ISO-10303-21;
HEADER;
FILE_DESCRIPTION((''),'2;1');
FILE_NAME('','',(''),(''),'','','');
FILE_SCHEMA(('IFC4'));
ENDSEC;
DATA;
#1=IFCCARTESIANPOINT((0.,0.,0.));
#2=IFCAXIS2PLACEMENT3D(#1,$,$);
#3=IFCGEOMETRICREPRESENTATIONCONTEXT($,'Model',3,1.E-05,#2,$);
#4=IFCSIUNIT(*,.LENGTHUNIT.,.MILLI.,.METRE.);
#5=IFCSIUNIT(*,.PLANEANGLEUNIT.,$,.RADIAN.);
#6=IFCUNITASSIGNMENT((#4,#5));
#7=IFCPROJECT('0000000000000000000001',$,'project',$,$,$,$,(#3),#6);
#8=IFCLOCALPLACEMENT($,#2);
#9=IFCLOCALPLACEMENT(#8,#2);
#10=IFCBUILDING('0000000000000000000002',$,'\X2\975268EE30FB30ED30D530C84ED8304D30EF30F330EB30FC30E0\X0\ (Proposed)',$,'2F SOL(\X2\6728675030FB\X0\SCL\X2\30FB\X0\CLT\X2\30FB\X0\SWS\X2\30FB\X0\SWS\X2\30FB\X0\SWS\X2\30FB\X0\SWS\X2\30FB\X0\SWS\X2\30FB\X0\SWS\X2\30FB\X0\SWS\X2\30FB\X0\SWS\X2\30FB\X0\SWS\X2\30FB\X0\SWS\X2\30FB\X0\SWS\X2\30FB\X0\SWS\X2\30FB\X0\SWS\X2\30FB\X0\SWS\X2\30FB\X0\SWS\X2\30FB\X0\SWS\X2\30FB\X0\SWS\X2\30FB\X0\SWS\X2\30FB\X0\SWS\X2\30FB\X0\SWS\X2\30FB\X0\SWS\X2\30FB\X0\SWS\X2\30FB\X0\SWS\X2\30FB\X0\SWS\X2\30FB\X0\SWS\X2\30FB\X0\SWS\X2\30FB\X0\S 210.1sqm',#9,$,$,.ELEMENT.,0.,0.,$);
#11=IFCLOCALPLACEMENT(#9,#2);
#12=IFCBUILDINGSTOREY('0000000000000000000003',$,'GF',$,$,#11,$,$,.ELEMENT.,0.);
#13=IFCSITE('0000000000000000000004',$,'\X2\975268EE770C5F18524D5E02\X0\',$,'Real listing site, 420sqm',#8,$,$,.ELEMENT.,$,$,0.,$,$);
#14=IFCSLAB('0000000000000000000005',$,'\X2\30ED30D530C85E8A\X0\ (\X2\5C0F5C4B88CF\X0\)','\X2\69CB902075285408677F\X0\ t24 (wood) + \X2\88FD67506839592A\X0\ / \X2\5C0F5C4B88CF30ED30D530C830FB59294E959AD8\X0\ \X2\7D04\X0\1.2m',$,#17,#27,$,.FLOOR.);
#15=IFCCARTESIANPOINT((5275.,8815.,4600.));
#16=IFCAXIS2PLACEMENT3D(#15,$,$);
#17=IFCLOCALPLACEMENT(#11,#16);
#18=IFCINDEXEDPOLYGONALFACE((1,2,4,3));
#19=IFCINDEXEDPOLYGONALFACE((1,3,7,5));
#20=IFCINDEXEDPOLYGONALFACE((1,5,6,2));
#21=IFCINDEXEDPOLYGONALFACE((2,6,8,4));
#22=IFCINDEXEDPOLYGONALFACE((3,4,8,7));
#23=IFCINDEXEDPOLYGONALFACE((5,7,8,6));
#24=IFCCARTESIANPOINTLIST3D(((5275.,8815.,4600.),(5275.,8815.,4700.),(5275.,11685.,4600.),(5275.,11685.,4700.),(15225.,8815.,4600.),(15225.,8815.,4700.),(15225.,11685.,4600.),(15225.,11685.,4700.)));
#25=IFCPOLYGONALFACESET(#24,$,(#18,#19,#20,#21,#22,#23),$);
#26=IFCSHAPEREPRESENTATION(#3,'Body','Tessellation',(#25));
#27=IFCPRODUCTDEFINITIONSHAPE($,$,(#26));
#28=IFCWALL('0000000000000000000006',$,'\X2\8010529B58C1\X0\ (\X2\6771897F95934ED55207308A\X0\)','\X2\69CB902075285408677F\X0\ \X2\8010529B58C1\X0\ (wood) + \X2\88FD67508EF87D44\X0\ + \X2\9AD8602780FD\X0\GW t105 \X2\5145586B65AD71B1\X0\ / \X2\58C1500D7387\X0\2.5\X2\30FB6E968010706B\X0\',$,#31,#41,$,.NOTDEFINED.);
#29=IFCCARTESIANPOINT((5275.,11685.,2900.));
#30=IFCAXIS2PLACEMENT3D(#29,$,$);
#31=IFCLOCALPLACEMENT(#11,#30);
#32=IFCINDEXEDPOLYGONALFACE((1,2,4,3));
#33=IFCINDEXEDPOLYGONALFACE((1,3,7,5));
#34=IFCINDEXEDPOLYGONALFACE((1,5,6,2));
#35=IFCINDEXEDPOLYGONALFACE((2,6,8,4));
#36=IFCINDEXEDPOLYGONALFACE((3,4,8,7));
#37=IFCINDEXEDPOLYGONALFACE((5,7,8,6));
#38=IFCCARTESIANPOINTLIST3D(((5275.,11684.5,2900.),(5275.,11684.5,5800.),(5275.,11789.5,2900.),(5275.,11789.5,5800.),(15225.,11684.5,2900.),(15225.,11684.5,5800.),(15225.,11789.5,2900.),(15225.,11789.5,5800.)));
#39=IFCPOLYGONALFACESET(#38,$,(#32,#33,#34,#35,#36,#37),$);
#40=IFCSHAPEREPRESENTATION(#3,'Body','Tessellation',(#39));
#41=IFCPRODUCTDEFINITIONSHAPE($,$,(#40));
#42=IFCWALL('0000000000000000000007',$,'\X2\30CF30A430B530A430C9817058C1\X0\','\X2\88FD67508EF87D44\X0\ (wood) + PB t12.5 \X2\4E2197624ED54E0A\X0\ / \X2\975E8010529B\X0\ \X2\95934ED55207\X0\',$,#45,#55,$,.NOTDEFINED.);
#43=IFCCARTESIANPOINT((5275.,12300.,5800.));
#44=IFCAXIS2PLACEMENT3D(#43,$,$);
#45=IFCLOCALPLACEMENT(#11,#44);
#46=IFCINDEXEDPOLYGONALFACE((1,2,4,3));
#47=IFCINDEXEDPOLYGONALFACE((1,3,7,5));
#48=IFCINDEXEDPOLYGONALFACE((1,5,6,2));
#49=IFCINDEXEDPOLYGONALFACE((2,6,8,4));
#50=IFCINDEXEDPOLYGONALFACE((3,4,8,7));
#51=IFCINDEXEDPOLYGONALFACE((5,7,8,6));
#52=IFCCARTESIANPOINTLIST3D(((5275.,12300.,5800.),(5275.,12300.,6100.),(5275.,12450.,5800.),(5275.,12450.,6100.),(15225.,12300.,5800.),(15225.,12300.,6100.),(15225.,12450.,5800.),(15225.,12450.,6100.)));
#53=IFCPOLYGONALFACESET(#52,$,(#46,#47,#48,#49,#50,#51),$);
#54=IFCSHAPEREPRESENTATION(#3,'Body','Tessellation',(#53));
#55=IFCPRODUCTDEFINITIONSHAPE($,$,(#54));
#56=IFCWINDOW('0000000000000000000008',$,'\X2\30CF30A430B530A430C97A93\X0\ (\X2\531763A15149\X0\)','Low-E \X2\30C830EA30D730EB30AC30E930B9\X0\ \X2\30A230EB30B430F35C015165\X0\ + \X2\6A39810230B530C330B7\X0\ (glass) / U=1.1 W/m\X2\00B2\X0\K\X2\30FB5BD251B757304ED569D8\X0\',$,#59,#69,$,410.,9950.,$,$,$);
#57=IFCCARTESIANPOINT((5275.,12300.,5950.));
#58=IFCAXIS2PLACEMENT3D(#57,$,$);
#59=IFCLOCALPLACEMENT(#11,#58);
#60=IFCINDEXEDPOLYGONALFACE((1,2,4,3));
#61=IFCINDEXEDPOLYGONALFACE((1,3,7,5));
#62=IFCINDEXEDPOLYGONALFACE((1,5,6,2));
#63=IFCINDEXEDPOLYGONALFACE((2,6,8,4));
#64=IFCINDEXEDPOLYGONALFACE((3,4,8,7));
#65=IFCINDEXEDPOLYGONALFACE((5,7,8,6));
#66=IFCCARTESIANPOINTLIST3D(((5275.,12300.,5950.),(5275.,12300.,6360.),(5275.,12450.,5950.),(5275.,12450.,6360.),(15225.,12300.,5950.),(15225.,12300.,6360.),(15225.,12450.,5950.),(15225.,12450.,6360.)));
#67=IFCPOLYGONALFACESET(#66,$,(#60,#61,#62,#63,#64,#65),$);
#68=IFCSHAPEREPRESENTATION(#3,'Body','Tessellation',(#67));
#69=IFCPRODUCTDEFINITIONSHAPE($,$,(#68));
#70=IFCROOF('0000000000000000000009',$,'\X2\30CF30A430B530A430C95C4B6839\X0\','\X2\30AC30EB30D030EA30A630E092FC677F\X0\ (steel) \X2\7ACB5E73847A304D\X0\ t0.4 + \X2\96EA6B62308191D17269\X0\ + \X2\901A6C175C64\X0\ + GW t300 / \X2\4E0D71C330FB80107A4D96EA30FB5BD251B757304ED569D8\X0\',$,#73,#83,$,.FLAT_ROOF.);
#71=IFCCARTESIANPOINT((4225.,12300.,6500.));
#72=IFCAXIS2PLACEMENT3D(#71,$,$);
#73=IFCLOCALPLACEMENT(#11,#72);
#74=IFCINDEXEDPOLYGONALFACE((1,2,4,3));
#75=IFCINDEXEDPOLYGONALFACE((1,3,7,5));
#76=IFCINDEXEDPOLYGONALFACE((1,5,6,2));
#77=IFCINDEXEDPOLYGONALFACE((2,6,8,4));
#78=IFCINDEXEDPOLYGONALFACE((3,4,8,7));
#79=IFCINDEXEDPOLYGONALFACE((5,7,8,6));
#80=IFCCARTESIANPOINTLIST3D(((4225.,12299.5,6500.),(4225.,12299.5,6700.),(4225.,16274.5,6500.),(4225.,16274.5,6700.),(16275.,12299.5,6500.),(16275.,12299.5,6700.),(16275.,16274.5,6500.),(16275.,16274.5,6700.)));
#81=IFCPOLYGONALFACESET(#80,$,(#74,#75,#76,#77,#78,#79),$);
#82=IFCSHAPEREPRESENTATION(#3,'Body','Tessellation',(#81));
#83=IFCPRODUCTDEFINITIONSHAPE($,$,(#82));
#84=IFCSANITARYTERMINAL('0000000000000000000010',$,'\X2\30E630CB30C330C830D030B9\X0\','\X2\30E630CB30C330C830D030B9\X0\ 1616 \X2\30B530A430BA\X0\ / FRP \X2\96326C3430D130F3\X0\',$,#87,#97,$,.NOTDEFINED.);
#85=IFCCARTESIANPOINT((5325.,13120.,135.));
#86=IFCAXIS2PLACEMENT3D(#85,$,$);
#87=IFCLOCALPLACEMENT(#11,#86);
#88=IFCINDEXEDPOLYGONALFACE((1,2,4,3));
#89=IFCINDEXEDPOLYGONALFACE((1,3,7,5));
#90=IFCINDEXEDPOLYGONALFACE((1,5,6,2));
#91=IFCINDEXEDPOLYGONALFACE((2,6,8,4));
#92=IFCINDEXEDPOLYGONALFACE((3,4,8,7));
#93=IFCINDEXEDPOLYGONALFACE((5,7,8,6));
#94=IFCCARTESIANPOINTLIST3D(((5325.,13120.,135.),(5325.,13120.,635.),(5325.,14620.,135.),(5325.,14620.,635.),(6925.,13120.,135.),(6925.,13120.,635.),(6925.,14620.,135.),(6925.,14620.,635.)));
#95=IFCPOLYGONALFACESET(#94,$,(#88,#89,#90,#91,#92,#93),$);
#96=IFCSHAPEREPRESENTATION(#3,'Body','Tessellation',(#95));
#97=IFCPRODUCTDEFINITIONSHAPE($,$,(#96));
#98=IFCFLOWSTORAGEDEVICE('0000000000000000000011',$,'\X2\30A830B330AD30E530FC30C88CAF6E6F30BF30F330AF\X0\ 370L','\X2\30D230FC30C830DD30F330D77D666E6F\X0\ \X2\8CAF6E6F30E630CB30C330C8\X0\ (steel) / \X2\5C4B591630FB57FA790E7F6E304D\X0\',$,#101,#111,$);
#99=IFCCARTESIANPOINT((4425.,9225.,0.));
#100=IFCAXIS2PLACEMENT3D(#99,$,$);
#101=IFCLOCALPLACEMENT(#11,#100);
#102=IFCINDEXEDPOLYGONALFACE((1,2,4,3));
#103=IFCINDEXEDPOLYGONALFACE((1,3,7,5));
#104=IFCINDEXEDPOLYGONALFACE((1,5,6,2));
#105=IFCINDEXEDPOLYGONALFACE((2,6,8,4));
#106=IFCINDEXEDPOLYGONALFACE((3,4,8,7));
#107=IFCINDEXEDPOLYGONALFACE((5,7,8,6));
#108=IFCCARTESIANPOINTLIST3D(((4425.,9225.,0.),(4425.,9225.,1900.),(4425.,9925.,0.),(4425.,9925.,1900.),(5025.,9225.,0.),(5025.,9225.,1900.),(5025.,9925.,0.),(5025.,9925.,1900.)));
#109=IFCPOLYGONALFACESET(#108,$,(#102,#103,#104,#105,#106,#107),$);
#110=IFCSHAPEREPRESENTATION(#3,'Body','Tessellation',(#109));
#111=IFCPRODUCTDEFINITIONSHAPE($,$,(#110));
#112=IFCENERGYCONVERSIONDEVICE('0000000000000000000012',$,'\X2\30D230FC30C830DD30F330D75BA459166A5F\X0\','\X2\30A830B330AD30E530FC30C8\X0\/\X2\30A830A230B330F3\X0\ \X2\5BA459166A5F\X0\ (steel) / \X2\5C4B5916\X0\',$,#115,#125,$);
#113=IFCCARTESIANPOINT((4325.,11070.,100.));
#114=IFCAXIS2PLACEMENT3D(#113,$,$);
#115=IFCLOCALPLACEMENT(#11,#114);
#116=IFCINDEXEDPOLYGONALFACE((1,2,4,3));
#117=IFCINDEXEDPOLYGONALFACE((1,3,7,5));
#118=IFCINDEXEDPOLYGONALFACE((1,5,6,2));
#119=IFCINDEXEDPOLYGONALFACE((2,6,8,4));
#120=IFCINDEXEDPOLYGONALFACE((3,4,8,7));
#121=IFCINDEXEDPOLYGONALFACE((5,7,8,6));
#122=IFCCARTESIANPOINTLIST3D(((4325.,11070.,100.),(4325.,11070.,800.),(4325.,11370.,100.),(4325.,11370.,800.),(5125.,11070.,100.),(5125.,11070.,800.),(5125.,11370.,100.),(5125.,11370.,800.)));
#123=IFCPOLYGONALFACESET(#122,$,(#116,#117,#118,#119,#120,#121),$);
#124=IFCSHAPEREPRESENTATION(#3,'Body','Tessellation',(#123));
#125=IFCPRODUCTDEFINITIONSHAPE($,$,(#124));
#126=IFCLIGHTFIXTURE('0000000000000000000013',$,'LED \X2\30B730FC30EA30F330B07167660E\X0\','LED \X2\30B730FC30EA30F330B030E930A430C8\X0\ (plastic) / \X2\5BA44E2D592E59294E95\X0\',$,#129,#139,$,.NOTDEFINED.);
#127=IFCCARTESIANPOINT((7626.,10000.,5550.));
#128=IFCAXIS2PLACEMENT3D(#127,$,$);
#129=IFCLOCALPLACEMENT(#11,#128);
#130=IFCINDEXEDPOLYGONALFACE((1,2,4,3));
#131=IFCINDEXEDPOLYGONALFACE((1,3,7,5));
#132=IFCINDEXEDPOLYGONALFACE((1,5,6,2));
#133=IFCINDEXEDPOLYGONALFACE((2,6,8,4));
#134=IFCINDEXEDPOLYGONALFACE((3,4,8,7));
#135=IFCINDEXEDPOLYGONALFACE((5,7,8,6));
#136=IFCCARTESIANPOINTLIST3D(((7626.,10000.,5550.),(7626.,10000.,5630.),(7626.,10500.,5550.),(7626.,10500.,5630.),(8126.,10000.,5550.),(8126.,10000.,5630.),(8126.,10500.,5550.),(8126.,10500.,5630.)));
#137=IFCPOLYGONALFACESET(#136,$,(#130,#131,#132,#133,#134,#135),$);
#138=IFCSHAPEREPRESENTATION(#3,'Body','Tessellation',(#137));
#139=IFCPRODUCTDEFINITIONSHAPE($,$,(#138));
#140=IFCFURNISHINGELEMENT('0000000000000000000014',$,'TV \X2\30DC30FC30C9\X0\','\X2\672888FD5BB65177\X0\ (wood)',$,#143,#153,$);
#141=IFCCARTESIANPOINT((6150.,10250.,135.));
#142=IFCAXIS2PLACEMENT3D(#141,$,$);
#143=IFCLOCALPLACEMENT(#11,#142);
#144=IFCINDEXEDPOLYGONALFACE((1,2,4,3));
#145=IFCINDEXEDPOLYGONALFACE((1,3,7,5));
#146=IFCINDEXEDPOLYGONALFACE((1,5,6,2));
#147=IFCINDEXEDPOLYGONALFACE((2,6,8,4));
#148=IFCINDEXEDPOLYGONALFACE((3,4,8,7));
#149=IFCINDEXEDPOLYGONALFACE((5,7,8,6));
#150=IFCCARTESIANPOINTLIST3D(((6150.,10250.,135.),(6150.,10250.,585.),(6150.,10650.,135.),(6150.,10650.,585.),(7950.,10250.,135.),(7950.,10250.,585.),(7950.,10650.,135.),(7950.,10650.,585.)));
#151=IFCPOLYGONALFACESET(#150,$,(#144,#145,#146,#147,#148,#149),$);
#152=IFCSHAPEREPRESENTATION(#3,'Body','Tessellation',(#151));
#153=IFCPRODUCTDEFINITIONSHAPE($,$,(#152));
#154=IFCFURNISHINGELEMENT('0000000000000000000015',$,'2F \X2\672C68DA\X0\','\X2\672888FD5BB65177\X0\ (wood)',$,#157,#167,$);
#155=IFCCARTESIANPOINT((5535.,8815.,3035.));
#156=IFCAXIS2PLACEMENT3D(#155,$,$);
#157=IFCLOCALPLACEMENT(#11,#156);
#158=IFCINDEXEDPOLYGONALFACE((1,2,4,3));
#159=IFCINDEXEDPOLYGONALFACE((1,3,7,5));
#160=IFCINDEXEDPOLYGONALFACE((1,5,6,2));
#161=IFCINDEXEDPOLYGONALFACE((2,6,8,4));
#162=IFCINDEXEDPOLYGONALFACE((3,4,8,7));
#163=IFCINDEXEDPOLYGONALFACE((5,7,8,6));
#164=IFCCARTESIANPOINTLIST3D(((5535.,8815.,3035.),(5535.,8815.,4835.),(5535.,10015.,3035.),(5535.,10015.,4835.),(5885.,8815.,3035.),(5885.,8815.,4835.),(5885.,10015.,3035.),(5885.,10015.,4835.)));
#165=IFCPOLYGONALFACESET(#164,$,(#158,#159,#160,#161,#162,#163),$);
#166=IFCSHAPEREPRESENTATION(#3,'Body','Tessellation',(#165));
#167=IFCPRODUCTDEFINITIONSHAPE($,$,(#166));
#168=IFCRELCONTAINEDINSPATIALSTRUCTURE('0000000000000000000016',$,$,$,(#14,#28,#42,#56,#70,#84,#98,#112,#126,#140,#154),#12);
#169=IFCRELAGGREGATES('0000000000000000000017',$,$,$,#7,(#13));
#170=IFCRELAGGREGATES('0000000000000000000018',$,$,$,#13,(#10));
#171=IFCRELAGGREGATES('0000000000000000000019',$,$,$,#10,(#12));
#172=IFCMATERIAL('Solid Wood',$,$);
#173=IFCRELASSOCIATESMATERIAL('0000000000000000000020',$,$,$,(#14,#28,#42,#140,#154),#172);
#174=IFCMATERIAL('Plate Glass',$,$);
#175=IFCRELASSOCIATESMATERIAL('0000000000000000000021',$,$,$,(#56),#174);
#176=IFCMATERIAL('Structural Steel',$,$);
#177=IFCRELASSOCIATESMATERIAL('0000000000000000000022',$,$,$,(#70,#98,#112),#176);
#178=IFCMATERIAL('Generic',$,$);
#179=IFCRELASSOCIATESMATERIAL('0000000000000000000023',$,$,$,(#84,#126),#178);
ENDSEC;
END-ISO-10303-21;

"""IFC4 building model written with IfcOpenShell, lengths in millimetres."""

from ifc_helpers import new_model, si_unit, frame, frame_2d, origin, place, context, project, spatial, rectangle, extrude, material, element, fill, save


model = new_model("IFC4")

# Units and contexts
model_context = context("Model", 3, precision=1e-05, world=origin())
ifc_project = project(units=[si_unit("LENGTHUNIT", "METRE", prefix="MILLI"), si_unit("PLANEANGLEUNIT", "RADIAN")], contexts=[model_context])

# Site, building, storey
site_placement = place(None, origin())
site = spatial("IfcSite", under=ifc_project, at=site_placement, Name="青森県弘前市", ObjectType="Real listing site, 420sqm", CompositionType="ELEMENT", RefElevation=0.0)
building_placement = place(site_placement, origin())
building = spatial("IfcBuilding", under=site, at=building_placement, Name="青森・ロフト付きワンルーム (Proposed)", ObjectType="2F SOL(木材・SCL・CLT・SWS・SWS・SWS・SWS・SWS・SWS・SWS・SWS・SWS・SWS・SWS・SWS・SWS・SWS・SWS・SWS・SWS・SWS・SWS・SWS・SWS・SWS・SWS・SWS・SWS・SWS・S 210.1sqm", CompositionType="ELEMENT", ElevationOfRefHeight=0.0, ElevationOfTerrain=0.0)
storey_placement = place(building_placement, origin())
storey = spatial("IfcBuildingStorey", under=building, at=storey_placement, Name="GF", CompositionType="ELEMENT", Elevation=0.0)

# Shared definitions
ifc_material_1 = material(Name="Solid Wood")

# Slab
slab_placement = place(storey_placement, frame((5275.0, 8815.0, 4600.0)))
element("IfcSlab", 1, at=slab_placement, inside=storey, material=ifc_material_1, Name="ロフト床 (小屋裏)", Description="構造用合板 t24 (wood) + 製材根太 / 小屋裏ロフト・天井高 約1.2m", PredefinedType="FLOOR", context=model_context, shape_type="SweptSolid", body=[
    extrude(rectangle(XDim=9950.0, YDim=2870.0, at=frame_2d((4975.0, 1435.0))), frame((5275.0, 8815.0, 4600.0)), (0.0, 0.0, 1.0), 100.0),
])

# Wall
wall_1_placement = place(storey_placement, frame((5275.0, 11685.0, 2900.0)))
element("IfcWall", 2, at=wall_1_placement, inside=storey, material=ifc_material_1, Name="耐力壁 (東西間仕切り)", Description="構造用合板 耐力壁 (wood) + 製材軸組 + 高性能GW t105 充填断熱 / 壁倍率2.5・準耐火", PredefinedType="NOTDEFINED", context=model_context, shape_type="SweptSolid", body=[
    extrude(rectangle(XDim=9950.0, YDim=105.0, at=frame_2d((4975.0, 52.0))), frame((5275.0, 11685.0, 2900.0)), (0.0, 0.0, 1.0), 2900.0),
])

# Wall, opening, window
wall_2_placement = place(storey_placement, frame((5275.0, 12300.0, 5800.0)))
wall_2 = element("IfcWall", 3, at=wall_2_placement, inside=storey, material=ifc_material_1, Name="ハイサイド腰壁", Description="製材軸組 (wood) + PB t12.5 両面仕上 / 非耐力 間仕切", PredefinedType="NOTDEFINED", context=model_context, shape_type="SweptSolid", body=[
    extrude(rectangle(XDim=9950.0, YDim=150.0, at=frame_2d((4975.0, 75.0))), frame((5275.0, 12300.0, 5800.0)), (0.0, 0.0, 1.0), 700.0),
])
opening_1_placement = place(storey_placement, frame((5275.0, 12300.0, 5950.0)))
opening_1 = element("IfcOpeningElement", 4, at=opening_1_placement, cuts=wall_2, PredefinedType="NOTDEFINED", context=model_context, shape_type="SweptSolid", body=[
    extrude(rectangle(XDim=9950.0, YDim=150.0, at=frame_2d((4975.0, 75.0))), frame((5275.0, 12300.0, 5950.0)), (0.0, 0.0, 1.0), 410.0),
])
ifc_material_2 = material(Name="Plate Glass")
window_placement = place(storey_placement, frame((5275.0, 12300.0, 5950.0)))
window = element("IfcWindow", 5, at=window_placement, inside=storey, material=ifc_material_2, Name="ハイサイド窓 (北採光)", Description="Low-E トリプルガラス アルゴン封入 + 樹脂サッシ (glass) / U=1.1 W/m²K・寒冷地仕様", OverallHeight=410.0, OverallWidth=9950.0, context=model_context, shape_type="SweptSolid", body=[
    extrude(rectangle(XDim=9950.0, YDim=150.0, at=frame_2d((4975.0, 75.0))), frame((5275.0, 12300.0, 5950.0)), (0.0, 0.0, 1.0), 410.0),
])
fill(opening_1, window)

# Roof
ifc_material_3 = material(Name="Structural Steel")
roof_placement = place(storey_placement, frame((4225.0, 12300.0, 6500.0)))
element("IfcRoof", 6, at=roof_placement, inside=storey, material=ifc_material_3, Name="ハイサイド屋根", Description="ガルバリウム鋼板 (steel) 立平葺き t0.4 + 雪止め金物 + 通気層 + GW t300 / 不燃・耐積雪・寒冷地仕様", PredefinedType="FLAT_ROOF", context=model_context, shape_type="SweptSolid", body=[
    extrude(rectangle(XDim=12050.0, YDim=3975.0, at=frame_2d((6025.0, 1987.0))), frame((4225.0, 12300.0, 6500.0)), (0.0, 0.0, 1.0), 200.0),
])

# Sanitary terminal
ifc_material_4 = material(Name="Generic")
sanitary_terminal_placement = place(storey_placement, frame((5325.0, 13120.0, 135.0)))
element("IfcSanitaryTerminal", 7, at=sanitary_terminal_placement, inside=storey, material=ifc_material_4, Name="ユニットバス", Description="ユニットバス 1616 サイズ / FRP 防水パン", PredefinedType="NOTDEFINED", context=model_context, shape_type="SweptSolid", body=[
    extrude(rectangle(XDim=1600.0, YDim=1500.0, at=frame_2d((800.0, 750.0))), frame((5325.0, 13120.0, 135.0)), (0.0, 0.0, 1.0), 500.0),
])

# Flow storage device
flow_storage_device_placement = place(storey_placement, frame((4425.0, 9225.0, 0.0)))
element("IfcFlowStorageDevice", 8, at=flow_storage_device_placement, inside=storey, material=ifc_material_3, Name="エコキュート貯湯タンク 370L", Description="ヒートポンプ給湯 貯湯ユニット (steel) / 屋外・基礎置き", context=model_context, shape_type="SweptSolid", body=[
    extrude(rectangle(XDim=600.0, YDim=700.0, at=frame_2d((300.0, 350.0))), frame((4425.0, 9225.0, 0.0)), (0.0, 0.0, 1.0), 1900.0),
])

# Energy conversion device
energy_conversion_device_placement = place(storey_placement, frame((4325.0, 11070.0, 100.0)))
element("IfcEnergyConversionDevice", 9, at=energy_conversion_device_placement, inside=storey, material=ifc_material_3, Name="ヒートポンプ室外機", Description="エコキュート/エアコン 室外機 (steel) / 屋外", context=model_context, shape_type="SweptSolid", body=[
    extrude(rectangle(XDim=800.0, YDim=300.0, at=frame_2d((400.0, 150.0))), frame((4325.0, 11070.0, 100.0)), (0.0, 0.0, 1.0), 700.0),
])

# Light fixture
light_fixture_placement = place(storey_placement, frame((7626.0, 10000.0, 5550.0)))
element("IfcLightFixture", 10, at=light_fixture_placement, inside=storey, material=ifc_material_4, Name="LED シーリング照明", Description="LED シーリングライト (plastic) / 室中央天井", PredefinedType="NOTDEFINED", context=model_context, shape_type="SweptSolid", body=[
    extrude(rectangle(XDim=500.0, YDim=500.0, at=frame_2d((250.0, 250.0))), frame((7626.0, 10000.0, 5550.0)), (0.0, 0.0, 1.0), 80.0),
])

# Furnishing elements
furnishing_1_placement = place(storey_placement, frame((6150.0, 10250.0, 135.0)))
element("IfcFurnishingElement", 11, at=furnishing_1_placement, inside=storey, material=ifc_material_1, Name="TV ボード", Description="木製家具 (wood)", context=model_context, shape_type="SweptSolid", body=[
    extrude(rectangle(XDim=1800.0, YDim=400.0, at=frame_2d((900.0, 200.0))), frame((6150.0, 10250.0, 135.0)), (0.0, 0.0, 1.0), 450.0),
])
furnishing_2_placement = place(storey_placement, frame((5535.0, 8815.0, 3035.0)))
element("IfcFurnishingElement", 12, at=furnishing_2_placement, inside=storey, material=ifc_material_1, Name="2F 本棚", Description="木製家具 (wood)", context=model_context, shape_type="SweptSolid", body=[
    extrude(rectangle(XDim=350.0, YDim=1200.0, at=frame_2d((175.0, 600.0))), frame((5535.0, 8815.0, 3035.0)), (0.0, 0.0, 1.0), 1800.0),
])

save(model, "model.ifc")
